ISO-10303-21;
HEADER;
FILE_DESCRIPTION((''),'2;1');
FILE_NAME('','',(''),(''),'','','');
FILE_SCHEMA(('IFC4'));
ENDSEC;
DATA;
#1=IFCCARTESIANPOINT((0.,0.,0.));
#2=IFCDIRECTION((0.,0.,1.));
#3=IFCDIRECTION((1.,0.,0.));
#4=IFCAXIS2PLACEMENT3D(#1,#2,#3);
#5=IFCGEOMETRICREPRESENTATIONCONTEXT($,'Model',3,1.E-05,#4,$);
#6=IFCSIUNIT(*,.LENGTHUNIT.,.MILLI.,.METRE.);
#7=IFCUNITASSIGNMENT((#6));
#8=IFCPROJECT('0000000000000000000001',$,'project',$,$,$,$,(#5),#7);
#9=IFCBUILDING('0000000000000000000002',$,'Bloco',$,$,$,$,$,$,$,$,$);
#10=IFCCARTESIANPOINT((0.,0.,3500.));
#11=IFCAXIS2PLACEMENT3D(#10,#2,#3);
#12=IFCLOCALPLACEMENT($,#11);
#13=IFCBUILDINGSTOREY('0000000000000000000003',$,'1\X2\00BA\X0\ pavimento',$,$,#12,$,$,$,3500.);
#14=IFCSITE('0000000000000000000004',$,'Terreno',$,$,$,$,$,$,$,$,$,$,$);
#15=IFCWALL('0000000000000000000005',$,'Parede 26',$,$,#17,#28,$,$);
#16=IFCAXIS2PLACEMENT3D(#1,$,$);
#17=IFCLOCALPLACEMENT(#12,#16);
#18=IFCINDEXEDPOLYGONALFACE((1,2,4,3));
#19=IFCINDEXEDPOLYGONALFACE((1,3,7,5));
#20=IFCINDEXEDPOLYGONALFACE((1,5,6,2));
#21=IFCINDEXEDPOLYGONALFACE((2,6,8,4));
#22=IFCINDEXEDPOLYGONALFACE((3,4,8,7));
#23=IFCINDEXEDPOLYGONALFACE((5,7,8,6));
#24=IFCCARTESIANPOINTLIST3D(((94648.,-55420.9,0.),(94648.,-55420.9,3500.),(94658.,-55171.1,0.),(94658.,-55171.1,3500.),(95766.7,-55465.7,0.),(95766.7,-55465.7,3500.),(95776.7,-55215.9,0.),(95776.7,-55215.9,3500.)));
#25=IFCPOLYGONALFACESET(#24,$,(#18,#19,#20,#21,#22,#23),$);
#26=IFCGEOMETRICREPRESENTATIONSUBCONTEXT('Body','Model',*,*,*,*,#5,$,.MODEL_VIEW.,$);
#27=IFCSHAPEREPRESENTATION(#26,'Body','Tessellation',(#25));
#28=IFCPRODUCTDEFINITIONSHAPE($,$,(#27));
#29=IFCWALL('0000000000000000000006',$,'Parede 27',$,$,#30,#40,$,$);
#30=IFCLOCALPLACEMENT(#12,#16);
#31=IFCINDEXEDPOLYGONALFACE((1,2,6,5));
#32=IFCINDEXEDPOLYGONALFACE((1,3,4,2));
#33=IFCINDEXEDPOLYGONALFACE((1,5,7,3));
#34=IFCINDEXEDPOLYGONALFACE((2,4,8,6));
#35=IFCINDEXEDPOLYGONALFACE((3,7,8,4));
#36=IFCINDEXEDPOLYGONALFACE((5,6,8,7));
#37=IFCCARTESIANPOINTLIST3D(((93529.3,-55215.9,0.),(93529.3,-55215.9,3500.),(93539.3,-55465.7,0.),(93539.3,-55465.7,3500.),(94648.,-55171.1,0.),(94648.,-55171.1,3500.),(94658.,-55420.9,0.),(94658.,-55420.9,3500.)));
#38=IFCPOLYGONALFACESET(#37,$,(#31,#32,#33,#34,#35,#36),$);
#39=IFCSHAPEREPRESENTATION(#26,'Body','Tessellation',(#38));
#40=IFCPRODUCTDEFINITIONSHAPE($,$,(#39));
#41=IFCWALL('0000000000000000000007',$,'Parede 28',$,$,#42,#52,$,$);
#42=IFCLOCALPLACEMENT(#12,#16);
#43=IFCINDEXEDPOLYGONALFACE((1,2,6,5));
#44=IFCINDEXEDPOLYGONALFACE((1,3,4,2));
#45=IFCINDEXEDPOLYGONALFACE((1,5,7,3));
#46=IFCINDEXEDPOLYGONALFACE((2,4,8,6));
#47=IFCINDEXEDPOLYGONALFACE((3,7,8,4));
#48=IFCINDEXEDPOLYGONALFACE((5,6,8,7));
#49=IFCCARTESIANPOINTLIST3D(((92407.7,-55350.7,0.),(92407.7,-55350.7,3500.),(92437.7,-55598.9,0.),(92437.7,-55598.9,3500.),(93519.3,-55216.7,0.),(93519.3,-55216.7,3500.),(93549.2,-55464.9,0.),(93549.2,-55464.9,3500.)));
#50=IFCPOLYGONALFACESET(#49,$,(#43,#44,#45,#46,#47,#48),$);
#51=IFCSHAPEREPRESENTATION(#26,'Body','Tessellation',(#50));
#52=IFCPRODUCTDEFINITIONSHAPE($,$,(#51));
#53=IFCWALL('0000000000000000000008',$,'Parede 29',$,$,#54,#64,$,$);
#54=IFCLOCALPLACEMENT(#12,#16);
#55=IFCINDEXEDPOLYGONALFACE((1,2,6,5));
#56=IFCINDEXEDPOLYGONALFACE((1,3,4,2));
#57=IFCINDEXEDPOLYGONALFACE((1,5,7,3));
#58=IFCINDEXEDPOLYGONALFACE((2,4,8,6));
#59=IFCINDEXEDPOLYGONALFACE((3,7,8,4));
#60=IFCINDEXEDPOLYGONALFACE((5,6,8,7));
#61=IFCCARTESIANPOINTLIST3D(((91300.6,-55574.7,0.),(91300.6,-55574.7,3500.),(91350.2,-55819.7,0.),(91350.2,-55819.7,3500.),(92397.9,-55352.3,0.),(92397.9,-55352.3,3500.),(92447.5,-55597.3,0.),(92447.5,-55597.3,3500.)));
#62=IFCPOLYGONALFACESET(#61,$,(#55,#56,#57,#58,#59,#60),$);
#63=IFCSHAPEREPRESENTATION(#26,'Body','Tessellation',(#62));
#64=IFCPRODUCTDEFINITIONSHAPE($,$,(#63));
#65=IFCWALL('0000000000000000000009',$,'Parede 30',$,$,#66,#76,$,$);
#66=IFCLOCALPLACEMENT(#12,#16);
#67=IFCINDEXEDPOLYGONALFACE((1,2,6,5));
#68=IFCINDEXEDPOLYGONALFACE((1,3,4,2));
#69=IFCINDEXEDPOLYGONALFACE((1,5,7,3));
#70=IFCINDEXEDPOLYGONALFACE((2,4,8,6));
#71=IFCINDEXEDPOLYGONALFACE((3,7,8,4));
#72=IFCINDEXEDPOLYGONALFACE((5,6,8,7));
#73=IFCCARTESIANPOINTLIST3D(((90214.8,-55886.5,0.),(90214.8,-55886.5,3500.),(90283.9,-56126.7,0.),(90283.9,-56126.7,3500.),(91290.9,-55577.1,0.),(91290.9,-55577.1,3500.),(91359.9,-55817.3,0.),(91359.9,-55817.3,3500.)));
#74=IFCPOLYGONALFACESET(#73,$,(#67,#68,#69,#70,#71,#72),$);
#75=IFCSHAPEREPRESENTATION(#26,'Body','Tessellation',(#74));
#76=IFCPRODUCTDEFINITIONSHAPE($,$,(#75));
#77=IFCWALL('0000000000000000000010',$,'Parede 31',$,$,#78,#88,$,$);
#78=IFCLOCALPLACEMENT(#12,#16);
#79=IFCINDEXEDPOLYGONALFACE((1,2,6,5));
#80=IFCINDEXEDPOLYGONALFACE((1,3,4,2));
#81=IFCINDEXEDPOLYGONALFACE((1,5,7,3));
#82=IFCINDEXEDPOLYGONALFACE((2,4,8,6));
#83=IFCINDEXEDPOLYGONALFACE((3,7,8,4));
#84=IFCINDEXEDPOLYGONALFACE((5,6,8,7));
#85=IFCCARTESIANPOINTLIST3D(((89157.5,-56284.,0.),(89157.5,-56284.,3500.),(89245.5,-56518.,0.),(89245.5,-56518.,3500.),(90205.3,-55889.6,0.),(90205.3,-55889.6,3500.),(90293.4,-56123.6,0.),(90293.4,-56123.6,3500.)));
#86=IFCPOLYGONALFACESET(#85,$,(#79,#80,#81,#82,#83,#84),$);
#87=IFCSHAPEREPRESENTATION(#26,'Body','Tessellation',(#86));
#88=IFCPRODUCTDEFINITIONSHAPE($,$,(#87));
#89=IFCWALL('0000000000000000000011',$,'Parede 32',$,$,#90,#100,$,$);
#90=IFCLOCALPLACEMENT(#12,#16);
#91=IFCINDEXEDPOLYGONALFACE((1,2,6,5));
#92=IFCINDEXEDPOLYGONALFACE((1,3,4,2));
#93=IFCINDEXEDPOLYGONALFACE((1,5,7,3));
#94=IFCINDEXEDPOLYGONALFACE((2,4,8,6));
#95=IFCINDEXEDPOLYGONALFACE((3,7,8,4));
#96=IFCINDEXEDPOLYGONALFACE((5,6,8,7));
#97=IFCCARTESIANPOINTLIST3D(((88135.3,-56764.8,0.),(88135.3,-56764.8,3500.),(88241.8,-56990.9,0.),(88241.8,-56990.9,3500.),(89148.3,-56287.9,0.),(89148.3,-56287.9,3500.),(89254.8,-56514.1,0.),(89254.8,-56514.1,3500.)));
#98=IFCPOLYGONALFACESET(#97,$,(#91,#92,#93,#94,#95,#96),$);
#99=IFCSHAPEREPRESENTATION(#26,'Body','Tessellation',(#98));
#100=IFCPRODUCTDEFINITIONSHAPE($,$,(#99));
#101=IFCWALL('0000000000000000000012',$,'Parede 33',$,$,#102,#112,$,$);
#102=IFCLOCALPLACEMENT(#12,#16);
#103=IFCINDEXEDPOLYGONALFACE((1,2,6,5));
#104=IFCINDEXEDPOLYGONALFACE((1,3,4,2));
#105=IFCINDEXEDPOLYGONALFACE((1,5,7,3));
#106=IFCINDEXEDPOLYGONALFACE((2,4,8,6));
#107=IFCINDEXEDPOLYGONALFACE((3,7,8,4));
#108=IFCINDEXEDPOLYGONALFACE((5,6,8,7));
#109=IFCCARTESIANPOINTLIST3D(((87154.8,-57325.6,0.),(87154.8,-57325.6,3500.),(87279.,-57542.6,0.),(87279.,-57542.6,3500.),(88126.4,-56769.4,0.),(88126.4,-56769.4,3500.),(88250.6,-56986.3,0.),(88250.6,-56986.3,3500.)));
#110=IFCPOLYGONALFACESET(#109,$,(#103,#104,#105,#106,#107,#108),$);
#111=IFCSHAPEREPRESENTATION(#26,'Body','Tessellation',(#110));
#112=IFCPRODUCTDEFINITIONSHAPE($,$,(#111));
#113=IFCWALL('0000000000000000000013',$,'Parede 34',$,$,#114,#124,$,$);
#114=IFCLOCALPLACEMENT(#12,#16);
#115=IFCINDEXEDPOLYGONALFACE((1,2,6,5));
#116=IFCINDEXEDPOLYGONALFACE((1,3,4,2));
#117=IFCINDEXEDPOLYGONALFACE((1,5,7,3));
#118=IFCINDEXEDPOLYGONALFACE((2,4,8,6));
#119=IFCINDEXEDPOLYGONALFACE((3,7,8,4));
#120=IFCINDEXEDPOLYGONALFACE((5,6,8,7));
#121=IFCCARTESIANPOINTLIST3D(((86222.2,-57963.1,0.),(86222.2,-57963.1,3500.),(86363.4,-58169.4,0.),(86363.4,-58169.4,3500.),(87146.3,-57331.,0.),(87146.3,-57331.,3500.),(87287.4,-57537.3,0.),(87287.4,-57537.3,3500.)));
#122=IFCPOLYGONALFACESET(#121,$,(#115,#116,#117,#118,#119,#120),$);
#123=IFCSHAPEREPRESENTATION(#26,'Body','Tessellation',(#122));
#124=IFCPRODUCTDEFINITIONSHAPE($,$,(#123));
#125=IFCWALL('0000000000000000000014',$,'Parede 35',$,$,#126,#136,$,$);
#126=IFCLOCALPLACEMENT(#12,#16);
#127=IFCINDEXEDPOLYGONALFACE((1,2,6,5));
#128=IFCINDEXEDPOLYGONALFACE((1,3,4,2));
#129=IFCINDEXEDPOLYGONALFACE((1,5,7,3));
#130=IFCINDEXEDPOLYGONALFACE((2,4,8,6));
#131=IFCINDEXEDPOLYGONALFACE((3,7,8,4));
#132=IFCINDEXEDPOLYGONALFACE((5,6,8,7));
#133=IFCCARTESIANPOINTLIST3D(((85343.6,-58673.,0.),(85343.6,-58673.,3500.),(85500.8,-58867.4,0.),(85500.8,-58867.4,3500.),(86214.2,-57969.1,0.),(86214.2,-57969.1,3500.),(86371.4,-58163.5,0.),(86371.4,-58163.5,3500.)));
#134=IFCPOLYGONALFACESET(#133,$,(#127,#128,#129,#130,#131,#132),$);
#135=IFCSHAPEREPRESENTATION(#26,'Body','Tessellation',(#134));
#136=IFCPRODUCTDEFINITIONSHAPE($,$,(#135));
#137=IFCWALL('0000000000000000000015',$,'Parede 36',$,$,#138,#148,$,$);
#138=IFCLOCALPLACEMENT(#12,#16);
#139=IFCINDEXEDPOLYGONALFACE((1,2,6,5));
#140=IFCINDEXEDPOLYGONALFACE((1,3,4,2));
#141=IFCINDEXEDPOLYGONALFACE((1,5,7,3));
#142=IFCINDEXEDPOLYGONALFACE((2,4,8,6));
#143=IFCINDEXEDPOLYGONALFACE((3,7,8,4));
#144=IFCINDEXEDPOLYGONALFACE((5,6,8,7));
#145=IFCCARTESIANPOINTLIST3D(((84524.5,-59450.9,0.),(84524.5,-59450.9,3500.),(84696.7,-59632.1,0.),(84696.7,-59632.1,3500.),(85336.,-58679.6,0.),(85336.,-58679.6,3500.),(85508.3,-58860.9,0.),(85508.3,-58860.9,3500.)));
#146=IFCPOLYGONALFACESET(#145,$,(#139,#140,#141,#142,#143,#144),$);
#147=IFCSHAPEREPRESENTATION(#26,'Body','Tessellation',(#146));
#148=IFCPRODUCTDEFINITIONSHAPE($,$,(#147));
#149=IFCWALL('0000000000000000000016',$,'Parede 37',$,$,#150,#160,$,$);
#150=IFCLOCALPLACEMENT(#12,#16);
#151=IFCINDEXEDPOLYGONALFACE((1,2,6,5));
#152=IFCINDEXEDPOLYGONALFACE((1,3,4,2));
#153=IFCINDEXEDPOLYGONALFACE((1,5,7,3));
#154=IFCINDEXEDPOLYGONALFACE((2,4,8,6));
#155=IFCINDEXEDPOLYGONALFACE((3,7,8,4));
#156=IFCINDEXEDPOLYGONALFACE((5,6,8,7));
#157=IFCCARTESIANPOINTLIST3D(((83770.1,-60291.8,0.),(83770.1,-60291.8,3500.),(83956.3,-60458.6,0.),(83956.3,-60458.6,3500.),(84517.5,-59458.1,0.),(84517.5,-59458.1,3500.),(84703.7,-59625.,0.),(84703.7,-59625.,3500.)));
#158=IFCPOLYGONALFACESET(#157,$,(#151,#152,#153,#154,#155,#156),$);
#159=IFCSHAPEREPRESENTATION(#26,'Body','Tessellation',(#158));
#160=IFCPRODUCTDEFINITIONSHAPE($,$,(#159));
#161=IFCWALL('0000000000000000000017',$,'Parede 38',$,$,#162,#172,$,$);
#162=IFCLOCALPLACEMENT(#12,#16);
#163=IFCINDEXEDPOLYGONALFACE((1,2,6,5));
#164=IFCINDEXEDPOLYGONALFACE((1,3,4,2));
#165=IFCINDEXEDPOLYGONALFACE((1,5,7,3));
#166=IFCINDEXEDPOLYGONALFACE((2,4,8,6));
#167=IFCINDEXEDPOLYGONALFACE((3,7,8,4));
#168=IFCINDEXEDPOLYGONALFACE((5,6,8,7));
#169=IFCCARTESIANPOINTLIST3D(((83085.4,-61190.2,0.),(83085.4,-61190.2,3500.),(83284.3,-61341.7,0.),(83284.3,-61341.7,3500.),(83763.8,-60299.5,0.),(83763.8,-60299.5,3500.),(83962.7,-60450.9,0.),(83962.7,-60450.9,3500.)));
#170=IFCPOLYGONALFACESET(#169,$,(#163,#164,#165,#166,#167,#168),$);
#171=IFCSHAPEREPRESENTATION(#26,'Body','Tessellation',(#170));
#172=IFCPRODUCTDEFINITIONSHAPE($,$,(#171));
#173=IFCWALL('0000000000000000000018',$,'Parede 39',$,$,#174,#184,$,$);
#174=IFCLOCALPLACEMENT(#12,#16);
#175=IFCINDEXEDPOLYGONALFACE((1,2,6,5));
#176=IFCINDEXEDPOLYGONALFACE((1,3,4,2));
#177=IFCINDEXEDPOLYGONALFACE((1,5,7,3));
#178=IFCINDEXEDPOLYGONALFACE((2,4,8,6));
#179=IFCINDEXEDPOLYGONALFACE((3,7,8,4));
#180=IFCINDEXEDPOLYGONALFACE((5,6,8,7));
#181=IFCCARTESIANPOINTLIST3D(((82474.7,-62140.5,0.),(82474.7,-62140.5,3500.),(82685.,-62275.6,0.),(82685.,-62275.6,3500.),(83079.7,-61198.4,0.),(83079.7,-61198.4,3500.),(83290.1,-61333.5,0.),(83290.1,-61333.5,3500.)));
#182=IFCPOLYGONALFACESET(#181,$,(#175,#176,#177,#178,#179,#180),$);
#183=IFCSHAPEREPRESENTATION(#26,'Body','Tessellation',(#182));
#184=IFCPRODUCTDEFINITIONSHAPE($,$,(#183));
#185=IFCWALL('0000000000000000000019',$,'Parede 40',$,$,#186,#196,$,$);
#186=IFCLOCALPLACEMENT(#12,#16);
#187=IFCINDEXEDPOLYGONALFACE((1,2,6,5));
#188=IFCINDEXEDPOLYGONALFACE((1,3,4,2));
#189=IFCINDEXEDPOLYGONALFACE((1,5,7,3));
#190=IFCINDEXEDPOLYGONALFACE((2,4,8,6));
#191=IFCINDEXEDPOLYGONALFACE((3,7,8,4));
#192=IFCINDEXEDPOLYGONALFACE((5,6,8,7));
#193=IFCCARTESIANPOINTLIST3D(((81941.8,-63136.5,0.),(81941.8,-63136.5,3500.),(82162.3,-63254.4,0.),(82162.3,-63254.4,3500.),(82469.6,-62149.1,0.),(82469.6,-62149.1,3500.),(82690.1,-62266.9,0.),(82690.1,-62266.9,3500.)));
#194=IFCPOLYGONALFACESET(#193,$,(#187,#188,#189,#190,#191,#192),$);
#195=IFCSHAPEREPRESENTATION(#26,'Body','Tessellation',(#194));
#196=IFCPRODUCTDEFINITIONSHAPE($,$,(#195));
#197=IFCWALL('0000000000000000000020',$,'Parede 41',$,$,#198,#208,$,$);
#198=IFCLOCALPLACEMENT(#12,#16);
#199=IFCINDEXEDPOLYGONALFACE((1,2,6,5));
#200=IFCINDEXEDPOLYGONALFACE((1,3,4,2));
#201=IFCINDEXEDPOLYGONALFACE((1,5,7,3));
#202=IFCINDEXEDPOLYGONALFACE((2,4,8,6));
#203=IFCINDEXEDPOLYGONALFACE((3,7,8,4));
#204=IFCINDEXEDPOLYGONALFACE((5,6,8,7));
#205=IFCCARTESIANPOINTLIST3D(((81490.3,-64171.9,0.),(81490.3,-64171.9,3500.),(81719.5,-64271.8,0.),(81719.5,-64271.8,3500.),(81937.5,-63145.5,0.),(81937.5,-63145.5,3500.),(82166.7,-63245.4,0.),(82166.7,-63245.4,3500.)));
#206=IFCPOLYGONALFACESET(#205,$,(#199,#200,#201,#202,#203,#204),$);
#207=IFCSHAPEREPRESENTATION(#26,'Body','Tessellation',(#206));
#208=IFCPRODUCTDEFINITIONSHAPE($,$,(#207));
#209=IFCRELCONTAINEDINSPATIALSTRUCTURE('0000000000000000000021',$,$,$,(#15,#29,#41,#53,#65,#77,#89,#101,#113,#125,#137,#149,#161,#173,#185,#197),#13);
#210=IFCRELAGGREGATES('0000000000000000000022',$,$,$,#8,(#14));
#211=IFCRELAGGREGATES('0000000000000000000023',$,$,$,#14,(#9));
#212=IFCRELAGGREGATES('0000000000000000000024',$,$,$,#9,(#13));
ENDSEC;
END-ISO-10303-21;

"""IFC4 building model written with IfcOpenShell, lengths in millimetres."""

from ifc_helpers import new_model, si_unit, frame, origin, origin_with_axes, place, context, subcontext, project, spatial, polyline, outline, extrude, element, save


model = new_model("IFC4")

# Units and contexts
model_context = context("Model", 3, precision=1e-05, world=origin_with_axes())
body_context = subcontext(model_context, "Body", "Model", "MODEL_VIEW")
ifc_project = project(units=[si_unit("LENGTHUNIT", "METRE", prefix="MILLI")], contexts=[model_context])

# Site, building, storey
site = spatial("IfcSite", under=ifc_project, Name="Terreno")
building = spatial("IfcBuilding", under=site, Name="Bloco")
storey_placement = place(None, frame((0.0, 0.0, 3500.0), z_axis=(0.0, 0.0, 1.0), x_axis=(1.0, 0.0, 0.0)))
storey = spatial("IfcBuildingStorey", under=building, at=storey_placement, Name="1º pavimento", Elevation=3500.0)

# Walls
wall_1_placement = place(storey_placement, origin_with_axes())
element("IfcWall", 1, at=wall_1_placement, inside=storey, Name="Parede 26", context=body_context, shape_type="SweptSolid", body=[
    extrude(outline(polyline([(95766.7, -55465.7), (94648.0, -55420.9), (94658.0, -55171.1), (95776.7, -55215.9), (95766.7, -55465.7)])), origin(), (0.0, 0.0, 1.0), 3500.0),
])
wall_2_placement = place(storey_placement, origin_with_axes())
element("IfcWall", 2, at=wall_2_placement, inside=storey, Name="Parede 27", context=body_context, shape_type="SweptSolid", body=[
    extrude(outline(polyline([(94658.0, -55420.9), (93539.3, -55465.7), (93529.3, -55215.9), (94648.0, -55171.1), (94658.0, -55420.9)])), origin(), (0.0, 0.0, 1.0), 3500.0),
])
wall_3_placement = place(storey_placement, origin_with_axes())
element("IfcWall", 3, at=wall_3_placement, inside=storey, Name="Parede 28", context=body_context, shape_type="SweptSolid", body=[
    extrude(outline(polyline([(93549.2, -55464.9), (92437.7, -55598.9), (92407.7, -55350.7), (93519.3, -55216.7), (93549.2, -55464.9)])), origin(), (0.0, 0.0, 1.0), 3500.0),
])
wall_4_placement = place(storey_placement, origin_with_axes())
element("IfcWall", 4, at=wall_4_placement, inside=storey, Name="Parede 29", context=body_context, shape_type="SweptSolid", body=[
    extrude(outline(polyline([(92447.5, -55597.3), (91350.2, -55819.7), (91300.6, -55574.7), (92397.9, -55352.3), (92447.5, -55597.3)])), origin(), (0.0, 0.0, 1.0), 3500.0),
])
wall_5_placement = place(storey_placement, origin_with_axes())
element("IfcWall", 5, at=wall_5_placement, inside=storey, Name="Parede 30", context=body_context, shape_type="SweptSolid", body=[
    extrude(outline(polyline([(91359.9, -55817.3), (90283.9, -56126.7), (90214.8, -55886.5), (91290.9, -55577.1), (91359.9, -55817.3)])), origin(), (0.0, 0.0, 1.0), 3500.0),
])
wall_6_placement = place(storey_placement, origin_with_axes())
element("IfcWall", 6, at=wall_6_placement, inside=storey, Name="Parede 31", context=body_context, shape_type="SweptSolid", body=[
    extrude(outline(polyline([(90293.4, -56123.6), (89245.5, -56518.0), (89157.5, -56284.0), (90205.3, -55889.6), (90293.4, -56123.6)])), origin(), (0.0, 0.0, 1.0), 3500.0),
])
wall_7_placement = place(storey_placement, origin_with_axes())
element("IfcWall", 7, at=wall_7_placement, inside=storey, Name="Parede 32", context=body_context, shape_type="SweptSolid", body=[
    extrude(outline(polyline([(89254.8, -56514.1), (88241.8, -56990.9), (88135.3, -56764.8), (89148.3, -56287.9), (89254.8, -56514.1)])), origin(), (0.0, 0.0, 1.0), 3500.0),
])
wall_8_placement = place(storey_placement, origin_with_axes())
element("IfcWall", 8, at=wall_8_placement, inside=storey, Name="Parede 33", context=body_context, shape_type="SweptSolid", body=[
    extrude(outline(polyline([(88250.6, -56986.3), (87279.0, -57542.6), (87154.8, -57325.6), (88126.4, -56769.4), (88250.6, -56986.3)])), origin(), (0.0, 0.0, 1.0), 3500.0),
])
wall_9_placement = place(storey_placement, origin_with_axes())
element("IfcWall", 9, at=wall_9_placement, inside=storey, Name="Parede 34", context=body_context, shape_type="SweptSolid", body=[
    extrude(outline(polyline([(87287.4, -57537.3), (86363.4, -58169.4), (86222.2, -57963.1), (87146.3, -57331.0), (87287.4, -57537.3)])), origin(), (0.0, 0.0, 1.0), 3500.0),
])
wall_10_placement = place(storey_placement, origin_with_axes())
element("IfcWall", 10, at=wall_10_placement, inside=storey, Name="Parede 35", context=body_context, shape_type="SweptSolid", body=[
    extrude(outline(polyline([(86371.4, -58163.5), (85500.8, -58867.4), (85343.6, -58673.0), (86214.2, -57969.1), (86371.4, -58163.5)])), origin(), (0.0, 0.0, 1.0), 3500.0),
])
wall_11_placement = place(storey_placement, origin_with_axes())
element("IfcWall", 11, at=wall_11_placement, inside=storey, Name="Parede 36", context=body_context, shape_type="SweptSolid", body=[
    extrude(outline(polyline([(85508.3, -58860.9), (84696.7, -59632.1), (84524.5, -59450.9), (85336.0, -58679.6), (85508.3, -58860.9)])), origin(), (0.0, 0.0, 1.0), 3500.0),
])
wall_12_placement = place(storey_placement, origin_with_axes())
element("IfcWall", 12, at=wall_12_placement, inside=storey, Name="Parede 37", context=body_context, shape_type="SweptSolid", body=[
    extrude(outline(polyline([(84703.7, -59625.0), (83956.3, -60458.6), (83770.1, -60291.8), (84517.5, -59458.1), (84703.7, -59625.0)])), origin(), (0.0, 0.0, 1.0), 3500.0),
])
wall_13_placement = place(storey_placement, origin_with_axes())
element("IfcWall", 13, at=wall_13_placement, inside=storey, Name="Parede 38", context=body_context, shape_type="SweptSolid", body=[
    extrude(outline(polyline([(83962.7, -60450.9), (83284.3, -61341.7), (83085.4, -61190.2), (83763.8, -60299.5), (83962.7, -60450.9)])), origin(), (0.0, 0.0, 1.0), 3500.0),
])
wall_14_placement = place(storey_placement, origin_with_axes())
element("IfcWall", 14, at=wall_14_placement, inside=storey, Name="Parede 39", context=body_context, shape_type="SweptSolid", body=[
    extrude(outline(polyline([(83290.1, -61333.5), (82685.0, -62275.6), (82474.7, -62140.5), (83079.7, -61198.4), (83290.1, -61333.5)])), origin(), (0.0, 0.0, 1.0), 3500.0),
])
wall_15_placement = place(storey_placement, origin_with_axes())
element("IfcWall", 15, at=wall_15_placement, inside=storey, Name="Parede 40", context=body_context, shape_type="SweptSolid", body=[
    extrude(outline(polyline([(82690.1, -62266.9), (82162.3, -63254.4), (81941.8, -63136.5), (82469.6, -62149.1), (82690.1, -62266.9)])), origin(), (0.0, 0.0, 1.0), 3500.0),
])
wall_16_placement = place(storey_placement, origin_with_axes())
element("IfcWall", 16, at=wall_16_placement, inside=storey, Name="Parede 41", context=body_context, shape_type="SweptSolid", body=[
    extrude(outline(polyline([(82166.7, -63245.4), (81719.5, -64271.8), (81490.3, -64171.9), (81937.5, -63145.5), (82166.7, -63245.4)])), origin(), (0.0, 0.0, 1.0), 3500.0),
])

save(model, "model.ifc")
